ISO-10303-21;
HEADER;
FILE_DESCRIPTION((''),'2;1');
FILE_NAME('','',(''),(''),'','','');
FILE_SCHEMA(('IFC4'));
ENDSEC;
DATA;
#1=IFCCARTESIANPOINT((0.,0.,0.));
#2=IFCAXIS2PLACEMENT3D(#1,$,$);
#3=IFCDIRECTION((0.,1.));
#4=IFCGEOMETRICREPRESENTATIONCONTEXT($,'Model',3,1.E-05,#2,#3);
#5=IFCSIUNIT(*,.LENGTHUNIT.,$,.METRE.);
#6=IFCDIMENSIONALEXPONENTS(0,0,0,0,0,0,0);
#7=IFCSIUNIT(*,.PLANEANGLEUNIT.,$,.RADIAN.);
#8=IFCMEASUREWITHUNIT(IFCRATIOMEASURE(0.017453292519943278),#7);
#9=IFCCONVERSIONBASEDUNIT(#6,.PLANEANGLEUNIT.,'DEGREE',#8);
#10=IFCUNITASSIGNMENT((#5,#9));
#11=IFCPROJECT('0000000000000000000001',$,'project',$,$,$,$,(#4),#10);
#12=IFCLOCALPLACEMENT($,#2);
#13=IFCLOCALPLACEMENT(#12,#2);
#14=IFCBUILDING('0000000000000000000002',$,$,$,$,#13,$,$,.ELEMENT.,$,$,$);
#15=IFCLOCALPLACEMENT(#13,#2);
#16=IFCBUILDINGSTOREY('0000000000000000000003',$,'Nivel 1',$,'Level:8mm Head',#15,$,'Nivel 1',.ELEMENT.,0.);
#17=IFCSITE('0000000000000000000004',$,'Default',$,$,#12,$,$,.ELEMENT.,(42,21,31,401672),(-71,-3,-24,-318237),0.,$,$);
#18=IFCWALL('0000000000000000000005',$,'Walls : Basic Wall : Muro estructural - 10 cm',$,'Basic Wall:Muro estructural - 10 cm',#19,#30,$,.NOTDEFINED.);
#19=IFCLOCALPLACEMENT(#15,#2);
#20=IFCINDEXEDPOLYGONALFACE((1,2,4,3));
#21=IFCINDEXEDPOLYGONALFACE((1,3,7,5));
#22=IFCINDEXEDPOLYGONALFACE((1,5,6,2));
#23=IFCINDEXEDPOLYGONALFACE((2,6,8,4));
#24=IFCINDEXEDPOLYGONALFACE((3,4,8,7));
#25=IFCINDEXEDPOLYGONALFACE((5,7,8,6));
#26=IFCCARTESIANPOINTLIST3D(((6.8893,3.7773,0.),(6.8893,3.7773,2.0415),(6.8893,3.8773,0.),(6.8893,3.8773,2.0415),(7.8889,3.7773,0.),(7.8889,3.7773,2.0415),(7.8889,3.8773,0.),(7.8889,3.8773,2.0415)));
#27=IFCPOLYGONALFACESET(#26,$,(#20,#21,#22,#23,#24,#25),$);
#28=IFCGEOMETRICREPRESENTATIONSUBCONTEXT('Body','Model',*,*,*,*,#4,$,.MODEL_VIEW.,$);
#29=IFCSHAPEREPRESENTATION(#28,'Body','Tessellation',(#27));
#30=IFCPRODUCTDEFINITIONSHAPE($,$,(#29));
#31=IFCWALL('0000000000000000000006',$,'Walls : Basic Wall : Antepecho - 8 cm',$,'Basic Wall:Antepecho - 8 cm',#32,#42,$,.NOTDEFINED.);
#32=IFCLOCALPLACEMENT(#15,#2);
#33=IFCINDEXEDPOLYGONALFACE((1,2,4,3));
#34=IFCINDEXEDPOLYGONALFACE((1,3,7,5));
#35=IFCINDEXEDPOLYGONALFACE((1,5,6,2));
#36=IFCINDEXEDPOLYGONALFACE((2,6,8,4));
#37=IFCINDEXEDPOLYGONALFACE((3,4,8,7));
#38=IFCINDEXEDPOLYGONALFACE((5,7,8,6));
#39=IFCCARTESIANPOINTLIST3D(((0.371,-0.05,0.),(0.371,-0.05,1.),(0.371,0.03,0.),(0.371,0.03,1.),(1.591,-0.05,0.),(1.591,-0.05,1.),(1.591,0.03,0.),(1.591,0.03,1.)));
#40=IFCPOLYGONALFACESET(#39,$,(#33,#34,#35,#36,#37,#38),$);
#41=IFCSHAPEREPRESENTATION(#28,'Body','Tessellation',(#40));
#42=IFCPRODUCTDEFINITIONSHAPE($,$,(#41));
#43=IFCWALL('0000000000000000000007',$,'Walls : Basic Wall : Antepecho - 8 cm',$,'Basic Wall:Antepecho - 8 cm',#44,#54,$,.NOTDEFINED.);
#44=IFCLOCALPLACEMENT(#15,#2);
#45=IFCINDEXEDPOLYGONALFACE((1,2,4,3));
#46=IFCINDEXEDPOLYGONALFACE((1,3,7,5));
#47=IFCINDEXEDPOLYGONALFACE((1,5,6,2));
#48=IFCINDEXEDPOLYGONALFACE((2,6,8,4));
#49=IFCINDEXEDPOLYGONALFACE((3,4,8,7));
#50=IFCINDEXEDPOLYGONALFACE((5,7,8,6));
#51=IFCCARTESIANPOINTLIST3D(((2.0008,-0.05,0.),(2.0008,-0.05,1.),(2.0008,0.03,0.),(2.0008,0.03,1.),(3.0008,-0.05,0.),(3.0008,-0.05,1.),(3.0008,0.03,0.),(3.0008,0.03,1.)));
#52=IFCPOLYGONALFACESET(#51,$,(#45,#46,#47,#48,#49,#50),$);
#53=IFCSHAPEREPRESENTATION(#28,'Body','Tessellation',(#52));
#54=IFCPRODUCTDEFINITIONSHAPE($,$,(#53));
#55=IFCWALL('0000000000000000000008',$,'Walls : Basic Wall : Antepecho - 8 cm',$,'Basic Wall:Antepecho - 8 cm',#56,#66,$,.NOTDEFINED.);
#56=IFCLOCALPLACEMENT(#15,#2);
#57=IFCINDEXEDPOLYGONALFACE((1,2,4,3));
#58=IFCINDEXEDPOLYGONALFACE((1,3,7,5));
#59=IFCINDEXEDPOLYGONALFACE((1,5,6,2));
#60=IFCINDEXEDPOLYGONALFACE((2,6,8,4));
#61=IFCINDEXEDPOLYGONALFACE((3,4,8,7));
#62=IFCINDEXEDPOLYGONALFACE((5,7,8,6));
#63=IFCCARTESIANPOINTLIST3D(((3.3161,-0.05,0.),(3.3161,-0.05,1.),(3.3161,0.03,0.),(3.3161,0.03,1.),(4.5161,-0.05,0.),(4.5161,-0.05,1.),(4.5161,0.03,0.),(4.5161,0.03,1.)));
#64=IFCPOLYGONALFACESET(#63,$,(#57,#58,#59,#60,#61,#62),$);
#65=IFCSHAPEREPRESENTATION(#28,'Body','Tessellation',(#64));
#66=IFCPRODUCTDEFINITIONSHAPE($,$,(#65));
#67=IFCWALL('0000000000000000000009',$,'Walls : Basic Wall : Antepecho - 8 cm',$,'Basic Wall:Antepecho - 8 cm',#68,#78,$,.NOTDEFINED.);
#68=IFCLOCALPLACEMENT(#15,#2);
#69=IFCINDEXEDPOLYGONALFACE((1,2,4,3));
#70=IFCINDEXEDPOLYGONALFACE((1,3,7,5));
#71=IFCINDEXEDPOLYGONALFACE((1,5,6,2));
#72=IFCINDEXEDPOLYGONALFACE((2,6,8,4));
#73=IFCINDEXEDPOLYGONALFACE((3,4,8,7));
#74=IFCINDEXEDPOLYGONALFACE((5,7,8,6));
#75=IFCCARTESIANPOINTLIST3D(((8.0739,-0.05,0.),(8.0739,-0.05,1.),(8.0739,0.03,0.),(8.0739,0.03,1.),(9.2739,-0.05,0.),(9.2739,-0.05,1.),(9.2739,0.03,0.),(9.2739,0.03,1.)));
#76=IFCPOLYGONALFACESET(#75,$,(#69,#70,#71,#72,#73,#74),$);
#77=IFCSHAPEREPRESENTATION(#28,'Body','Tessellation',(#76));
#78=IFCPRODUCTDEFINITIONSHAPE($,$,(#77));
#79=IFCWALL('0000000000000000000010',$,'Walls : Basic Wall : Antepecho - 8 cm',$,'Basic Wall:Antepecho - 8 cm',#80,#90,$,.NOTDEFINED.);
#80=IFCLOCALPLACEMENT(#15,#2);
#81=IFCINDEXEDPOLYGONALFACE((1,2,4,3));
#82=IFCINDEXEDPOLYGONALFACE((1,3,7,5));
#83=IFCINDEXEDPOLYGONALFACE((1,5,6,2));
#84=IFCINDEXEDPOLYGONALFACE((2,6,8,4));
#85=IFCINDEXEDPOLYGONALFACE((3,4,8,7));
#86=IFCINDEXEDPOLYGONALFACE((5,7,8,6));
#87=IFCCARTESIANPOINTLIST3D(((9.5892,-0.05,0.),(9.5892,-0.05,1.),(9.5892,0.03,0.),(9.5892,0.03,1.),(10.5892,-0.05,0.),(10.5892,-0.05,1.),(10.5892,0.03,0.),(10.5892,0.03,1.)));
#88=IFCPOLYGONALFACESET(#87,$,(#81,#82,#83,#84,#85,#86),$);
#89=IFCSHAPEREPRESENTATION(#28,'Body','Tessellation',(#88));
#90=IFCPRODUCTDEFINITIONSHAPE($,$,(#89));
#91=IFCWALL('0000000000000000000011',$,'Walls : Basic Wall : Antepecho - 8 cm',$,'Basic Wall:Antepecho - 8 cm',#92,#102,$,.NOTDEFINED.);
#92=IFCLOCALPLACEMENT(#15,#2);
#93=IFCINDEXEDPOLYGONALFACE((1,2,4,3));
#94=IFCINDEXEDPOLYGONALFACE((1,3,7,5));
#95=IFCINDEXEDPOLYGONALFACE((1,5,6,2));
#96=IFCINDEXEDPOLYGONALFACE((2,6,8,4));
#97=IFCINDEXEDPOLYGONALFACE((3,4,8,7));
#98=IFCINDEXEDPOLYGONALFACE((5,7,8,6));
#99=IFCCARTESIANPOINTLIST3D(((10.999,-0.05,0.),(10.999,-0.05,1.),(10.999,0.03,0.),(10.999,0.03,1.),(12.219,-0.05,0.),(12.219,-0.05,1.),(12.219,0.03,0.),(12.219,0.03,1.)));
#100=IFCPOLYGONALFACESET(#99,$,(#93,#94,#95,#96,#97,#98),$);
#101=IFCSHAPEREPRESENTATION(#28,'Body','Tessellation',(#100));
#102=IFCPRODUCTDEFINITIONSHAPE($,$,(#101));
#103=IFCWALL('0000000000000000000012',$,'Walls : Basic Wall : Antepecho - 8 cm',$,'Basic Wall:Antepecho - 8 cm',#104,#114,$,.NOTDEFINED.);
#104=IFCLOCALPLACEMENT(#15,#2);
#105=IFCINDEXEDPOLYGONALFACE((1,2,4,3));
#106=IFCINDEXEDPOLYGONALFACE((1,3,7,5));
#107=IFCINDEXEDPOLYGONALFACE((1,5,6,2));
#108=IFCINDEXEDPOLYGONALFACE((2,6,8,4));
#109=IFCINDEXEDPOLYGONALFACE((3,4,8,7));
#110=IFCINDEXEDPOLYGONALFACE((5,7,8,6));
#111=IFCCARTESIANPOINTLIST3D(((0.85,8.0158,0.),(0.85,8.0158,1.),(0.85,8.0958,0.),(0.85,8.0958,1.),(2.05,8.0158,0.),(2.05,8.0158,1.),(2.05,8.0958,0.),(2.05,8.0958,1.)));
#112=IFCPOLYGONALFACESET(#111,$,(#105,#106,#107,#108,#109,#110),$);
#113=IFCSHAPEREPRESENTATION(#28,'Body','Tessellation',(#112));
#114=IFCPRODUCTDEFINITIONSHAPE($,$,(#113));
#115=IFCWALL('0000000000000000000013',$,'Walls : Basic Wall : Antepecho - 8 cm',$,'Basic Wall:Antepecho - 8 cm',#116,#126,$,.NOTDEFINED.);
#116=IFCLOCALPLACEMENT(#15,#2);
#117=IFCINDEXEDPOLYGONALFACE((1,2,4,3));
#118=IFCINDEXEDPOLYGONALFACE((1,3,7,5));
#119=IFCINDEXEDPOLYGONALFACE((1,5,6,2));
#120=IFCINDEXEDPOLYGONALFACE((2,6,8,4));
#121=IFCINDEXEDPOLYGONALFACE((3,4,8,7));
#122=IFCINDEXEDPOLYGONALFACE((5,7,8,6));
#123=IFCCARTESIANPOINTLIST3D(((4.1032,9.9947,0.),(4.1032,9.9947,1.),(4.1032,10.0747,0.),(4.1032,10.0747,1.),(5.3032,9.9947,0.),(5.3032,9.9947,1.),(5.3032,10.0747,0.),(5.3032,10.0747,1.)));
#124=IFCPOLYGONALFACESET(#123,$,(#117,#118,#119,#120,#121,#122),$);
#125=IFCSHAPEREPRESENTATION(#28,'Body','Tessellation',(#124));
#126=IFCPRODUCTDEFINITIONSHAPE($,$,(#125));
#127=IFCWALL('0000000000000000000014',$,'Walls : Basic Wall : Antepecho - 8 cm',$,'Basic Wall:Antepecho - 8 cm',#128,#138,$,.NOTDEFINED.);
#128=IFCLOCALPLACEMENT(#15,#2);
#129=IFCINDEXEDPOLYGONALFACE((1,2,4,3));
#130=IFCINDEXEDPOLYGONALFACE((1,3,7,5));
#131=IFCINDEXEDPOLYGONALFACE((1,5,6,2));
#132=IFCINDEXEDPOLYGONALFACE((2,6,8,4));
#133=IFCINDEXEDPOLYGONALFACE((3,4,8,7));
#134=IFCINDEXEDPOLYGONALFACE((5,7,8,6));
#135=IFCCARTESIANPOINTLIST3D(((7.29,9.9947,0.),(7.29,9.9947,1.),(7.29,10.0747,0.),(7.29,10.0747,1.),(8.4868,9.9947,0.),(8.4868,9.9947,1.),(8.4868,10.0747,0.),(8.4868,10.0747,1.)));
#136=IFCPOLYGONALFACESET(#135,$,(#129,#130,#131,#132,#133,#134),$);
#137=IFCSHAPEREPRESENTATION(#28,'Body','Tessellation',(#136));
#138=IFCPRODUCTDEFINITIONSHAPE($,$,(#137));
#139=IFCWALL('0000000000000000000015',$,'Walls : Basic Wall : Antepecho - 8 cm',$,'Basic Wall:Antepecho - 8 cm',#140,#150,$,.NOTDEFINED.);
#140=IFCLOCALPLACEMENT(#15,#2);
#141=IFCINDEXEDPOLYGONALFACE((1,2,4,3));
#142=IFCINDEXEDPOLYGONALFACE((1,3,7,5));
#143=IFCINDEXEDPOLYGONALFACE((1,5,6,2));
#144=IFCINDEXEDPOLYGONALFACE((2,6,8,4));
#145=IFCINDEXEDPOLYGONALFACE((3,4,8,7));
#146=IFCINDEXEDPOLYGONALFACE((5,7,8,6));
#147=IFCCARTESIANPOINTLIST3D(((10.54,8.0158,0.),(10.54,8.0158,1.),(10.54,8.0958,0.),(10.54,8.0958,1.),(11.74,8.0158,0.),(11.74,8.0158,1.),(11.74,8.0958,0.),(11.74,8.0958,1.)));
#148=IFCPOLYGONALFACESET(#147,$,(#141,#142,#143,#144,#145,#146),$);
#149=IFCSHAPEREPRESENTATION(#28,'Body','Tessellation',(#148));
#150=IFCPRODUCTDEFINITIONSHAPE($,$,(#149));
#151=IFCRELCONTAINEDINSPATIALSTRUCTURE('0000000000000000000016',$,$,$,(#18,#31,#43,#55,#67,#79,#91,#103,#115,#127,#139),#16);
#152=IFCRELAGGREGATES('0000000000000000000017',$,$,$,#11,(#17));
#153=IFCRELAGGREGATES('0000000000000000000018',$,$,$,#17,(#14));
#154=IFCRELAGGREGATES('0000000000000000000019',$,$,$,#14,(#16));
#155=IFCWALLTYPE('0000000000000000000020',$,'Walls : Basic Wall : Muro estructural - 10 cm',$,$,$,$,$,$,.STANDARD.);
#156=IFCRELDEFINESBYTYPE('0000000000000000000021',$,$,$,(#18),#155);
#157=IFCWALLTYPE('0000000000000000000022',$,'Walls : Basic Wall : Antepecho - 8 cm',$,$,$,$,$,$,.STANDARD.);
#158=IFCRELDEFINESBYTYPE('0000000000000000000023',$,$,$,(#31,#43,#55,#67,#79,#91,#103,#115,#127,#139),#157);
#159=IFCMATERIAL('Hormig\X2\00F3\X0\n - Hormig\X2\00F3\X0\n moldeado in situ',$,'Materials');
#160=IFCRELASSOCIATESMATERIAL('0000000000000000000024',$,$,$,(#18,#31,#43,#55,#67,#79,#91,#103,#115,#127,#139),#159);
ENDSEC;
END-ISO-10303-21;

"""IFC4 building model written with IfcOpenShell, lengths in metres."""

from ifc_helpers import new_model, entity, si_unit, converted_unit, direction, frame, origin, place, context, subcontext, project, spatial, indexed_curve, outline, extrude, material, type_object, element, save


model = new_model("IFC4")

# Units and contexts
model_context = context("Model", 3, precision=1e-05, world=origin(), true_north=direction((0.0, 1.0)))
body_context = subcontext(model_context, "Body", "Model", "MODEL_VIEW")
ifc_project = project(units=[si_unit("LENGTHUNIT", "METRE"), converted_unit("PLANEANGLEUNIT", "DEGREE", entity("IfcRatioMeasure", 0.017453292519943278), si_unit("PLANEANGLEUNIT", "RADIAN"), dimensions=[0, 0, 0, 0, 0, 0, 0])], contexts=[model_context])

# Site, building, storey
site_placement = place(None, origin())
site = spatial("IfcSite", under=ifc_project, at=site_placement, Name="Default", CompositionType="ELEMENT", RefLatitude=(42, 21, 31, 401672), RefLongitude=(-71, -3, -24, -318237), RefElevation=0.0)
building_placement = place(site_placement, origin())
building = spatial("IfcBuilding", under=site, at=building_placement, CompositionType="ELEMENT")
storey_placement = place(building_placement, origin())
storey = spatial("IfcBuildingStorey", under=building, at=storey_placement, Name="Nivel 1", ObjectType="Level:8mm Head", LongName="Nivel 1", CompositionType="ELEMENT", Elevation=0.0)

# Walls
ifc_material_1 = material(Name="Hormigón - Hormigón moldeado in situ", Category="Materials")
wall_type_1 = type_object("IfcWallType", Name="Walls : Basic Wall : Muro estructural - 10 cm", PredefinedType="STANDARD")
wall_1_placement = place(storey_placement, frame((6.8893, 3.8273, 0.0)))
element("IfcWall", 1, at=wall_1_placement, inside=storey, type_object=wall_type_1, material=ifc_material_1, Name="Walls : Basic Wall : Muro estructural - 10 cm", ObjectType="Basic Wall:Muro estructural - 10 cm", PredefinedType="NOTDEFINED", context=body_context, shape_type="SweptSolid", body=[
    extrude(outline(indexed_curve([(0.9996, 0.05), (0.0, 0.05), (0.0, -0.05), (0.9996, -0.05), (0.9996, 0.05)], self_intersect=False)), origin(), (0.0, 0.0, 1.0), 2.0415),
])
wall_type_2 = type_object("IfcWallType", Name="Walls : Basic Wall : Antepecho - 8 cm", PredefinedType="STANDARD")
wall_2_placement = place(storey_placement, frame((0.371, -0.01, 0.0)))
element("IfcWall", 2, at=wall_2_placement, inside=storey, type_object=wall_type_2, material=ifc_material_1, Name="Walls : Basic Wall : Antepecho - 8 cm", ObjectType="Basic Wall:Antepecho - 8 cm", PredefinedType="NOTDEFINED", context=body_context, shape_type="SweptSolid", body=[
    extrude(outline(indexed_curve([(1.22, 0.04), (0.0, 0.04), (0.0, -0.04), (1.22, -0.04), (1.22, 0.04)], self_intersect=False)), origin(), (0.0, 0.0, 1.0), 1.0),
])
wall_3_placement = place(storey_placement, frame((2.0008, -0.01, 0.0)))
element("IfcWall", 3, at=wall_3_placement, inside=storey, type_object=wall_type_2, material=ifc_material_1, Name="Walls : Basic Wall : Antepecho - 8 cm", ObjectType="Basic Wall:Antepecho - 8 cm", PredefinedType="NOTDEFINED", context=body_context, shape_type="SweptSolid", body=[
    extrude(outline(indexed_curve([(1.0, 0.04), (0.0, 0.04), (0.0, -0.04), (1.0, -0.04), (1.0, 0.04)], self_intersect=False)), origin(), (0.0, 0.0, 1.0), 1.0),
])
wall_4_placement = place(storey_placement, frame((3.3161, -0.01, 0.0)))
element("IfcWall", 4, at=wall_4_placement, inside=storey, type_object=wall_type_2, material=ifc_material_1, Name="Walls : Basic Wall : Antepecho - 8 cm", ObjectType="Basic Wall:Antepecho - 8 cm", PredefinedType="NOTDEFINED", context=body_context, shape_type="SweptSolid", body=[
    extrude(outline(indexed_curve([(1.2, 0.04), (0.0, 0.04), (0.0, -0.04), (1.2, -0.04), (1.2, 0.04)], self_intersect=False)), origin(), (0.0, 0.0, 1.0), 1.0),
])
wall_5_placement = place(storey_placement, frame((8.0739, -0.01, 0.0)))
element("IfcWall", 5, at=wall_5_placement, inside=storey, type_object=wall_type_2, material=ifc_material_1, Name="Walls : Basic Wall : Antepecho - 8 cm", ObjectType="Basic Wall:Antepecho - 8 cm", PredefinedType="NOTDEFINED", context=body_context, shape_type="SweptSolid", body=[
    extrude(outline(indexed_curve([(1.2, 0.04), (0.0, 0.04), (0.0, -0.04), (1.2, -0.04), (1.2, 0.04)], self_intersect=False)), origin(), (0.0, 0.0, 1.0), 1.0),
])
wall_6_placement = place(storey_placement, frame((9.5892, -0.01, 0.0)))
element("IfcWall", 6, at=wall_6_placement, inside=storey, type_object=wall_type_2, material=ifc_material_1, Name="Walls : Basic Wall : Antepecho - 8 cm", ObjectType="Basic Wall:Antepecho - 8 cm", PredefinedType="NOTDEFINED", context=body_context, shape_type="SweptSolid", body=[
    extrude(outline(indexed_curve([(1.0, 0.04), (0.0, 0.04), (0.0, -0.04), (1.0, -0.04), (1.0, 0.04)], self_intersect=False)), origin(), (0.0, 0.0, 1.0), 1.0),
])
wall_7_placement = place(storey_placement, frame((10.999, -0.01, 0.0)))
element("IfcWall", 7, at=wall_7_placement, inside=storey, type_object=wall_type_2, material=ifc_material_1, Name="Walls : Basic Wall : Antepecho - 8 cm", ObjectType="Basic Wall:Antepecho - 8 cm", PredefinedType="NOTDEFINED", context=body_context, shape_type="SweptSolid", body=[
    extrude(outline(indexed_curve([(1.22, 0.04), (0.0, 0.04), (0.0, -0.04), (1.22, -0.04), (1.22, 0.04)], self_intersect=False)), origin(), (0.0, 0.0, 1.0), 1.0),
])
wall_8_placement = place(storey_placement, frame((2.05, 8.0558, 0.0), z_axis=(0.0, 0.0, 1.0), x_axis=(-1.0, 0.0, 0.0)))
element("IfcWall", 8, at=wall_8_placement, inside=storey, type_object=wall_type_2, material=ifc_material_1, Name="Walls : Basic Wall : Antepecho - 8 cm", ObjectType="Basic Wall:Antepecho - 8 cm", PredefinedType="NOTDEFINED", context=body_context, shape_type="SweptSolid", body=[
    extrude(outline(indexed_curve([(1.2, 0.04), (0.0, 0.04), (0.0, -0.04), (1.2, -0.04), (1.2, 0.04)], self_intersect=False)), origin(), (0.0, 0.0, 1.0), 1.0),
])
wall_9_placement = place(storey_placement, frame((5.3032, 10.0347, 0.0), z_axis=(0.0, 0.0, 1.0), x_axis=(-1.0, 0.0, 0.0)))
element("IfcWall", 9, at=wall_9_placement, inside=storey, type_object=wall_type_2, material=ifc_material_1, Name="Walls : Basic Wall : Antepecho - 8 cm", ObjectType="Basic Wall:Antepecho - 8 cm", PredefinedType="NOTDEFINED", context=body_context, shape_type="SweptSolid", body=[
    extrude(outline(indexed_curve([(1.2, 0.04), (0.0, 0.04), (0.0, -0.04), (1.2, -0.04), (1.2, 0.04)], self_intersect=False)), origin(), (0.0, 0.0, 1.0), 1.0),
])
wall_10_placement = place(storey_placement, frame((8.4868, 10.0347, 0.0), z_axis=(0.0, 0.0, 1.0), x_axis=(-1.0, 0.0, 0.0)))
element("IfcWall", 10, at=wall_10_placement, inside=storey, type_object=wall_type_2, material=ifc_material_1, Name="Walls : Basic Wall : Antepecho - 8 cm", ObjectType="Basic Wall:Antepecho - 8 cm", PredefinedType="NOTDEFINED", context=body_context, shape_type="SweptSolid", body=[
    extrude(outline(indexed_curve([(1.1968, 0.04), (0.0, 0.04), (0.0, -0.04), (1.1968, -0.04), (1.1968, 0.04)], self_intersect=False)), origin(), (0.0, 0.0, 1.0), 1.0),
])
wall_11_placement = place(storey_placement, frame((11.74, 8.0558, 0.0), z_axis=(0.0, 0.0, 1.0), x_axis=(-1.0, 0.0, 0.0)))
element("IfcWall", 11, at=wall_11_placement, inside=storey, type_object=wall_type_2, material=ifc_material_1, Name="Walls : Basic Wall : Antepecho - 8 cm", ObjectType="Basic Wall:Antepecho - 8 cm", PredefinedType="NOTDEFINED", context=body_context, shape_type="SweptSolid", body=[
    extrude(outline(indexed_curve([(1.2, 0.04), (0.0, 0.04), (0.0, -0.04), (1.2, -0.04), (1.2, 0.04)], self_intersect=False)), origin(), (0.0, 0.0, 1.0), 1.0),
])

save(model, "model.ifc")
